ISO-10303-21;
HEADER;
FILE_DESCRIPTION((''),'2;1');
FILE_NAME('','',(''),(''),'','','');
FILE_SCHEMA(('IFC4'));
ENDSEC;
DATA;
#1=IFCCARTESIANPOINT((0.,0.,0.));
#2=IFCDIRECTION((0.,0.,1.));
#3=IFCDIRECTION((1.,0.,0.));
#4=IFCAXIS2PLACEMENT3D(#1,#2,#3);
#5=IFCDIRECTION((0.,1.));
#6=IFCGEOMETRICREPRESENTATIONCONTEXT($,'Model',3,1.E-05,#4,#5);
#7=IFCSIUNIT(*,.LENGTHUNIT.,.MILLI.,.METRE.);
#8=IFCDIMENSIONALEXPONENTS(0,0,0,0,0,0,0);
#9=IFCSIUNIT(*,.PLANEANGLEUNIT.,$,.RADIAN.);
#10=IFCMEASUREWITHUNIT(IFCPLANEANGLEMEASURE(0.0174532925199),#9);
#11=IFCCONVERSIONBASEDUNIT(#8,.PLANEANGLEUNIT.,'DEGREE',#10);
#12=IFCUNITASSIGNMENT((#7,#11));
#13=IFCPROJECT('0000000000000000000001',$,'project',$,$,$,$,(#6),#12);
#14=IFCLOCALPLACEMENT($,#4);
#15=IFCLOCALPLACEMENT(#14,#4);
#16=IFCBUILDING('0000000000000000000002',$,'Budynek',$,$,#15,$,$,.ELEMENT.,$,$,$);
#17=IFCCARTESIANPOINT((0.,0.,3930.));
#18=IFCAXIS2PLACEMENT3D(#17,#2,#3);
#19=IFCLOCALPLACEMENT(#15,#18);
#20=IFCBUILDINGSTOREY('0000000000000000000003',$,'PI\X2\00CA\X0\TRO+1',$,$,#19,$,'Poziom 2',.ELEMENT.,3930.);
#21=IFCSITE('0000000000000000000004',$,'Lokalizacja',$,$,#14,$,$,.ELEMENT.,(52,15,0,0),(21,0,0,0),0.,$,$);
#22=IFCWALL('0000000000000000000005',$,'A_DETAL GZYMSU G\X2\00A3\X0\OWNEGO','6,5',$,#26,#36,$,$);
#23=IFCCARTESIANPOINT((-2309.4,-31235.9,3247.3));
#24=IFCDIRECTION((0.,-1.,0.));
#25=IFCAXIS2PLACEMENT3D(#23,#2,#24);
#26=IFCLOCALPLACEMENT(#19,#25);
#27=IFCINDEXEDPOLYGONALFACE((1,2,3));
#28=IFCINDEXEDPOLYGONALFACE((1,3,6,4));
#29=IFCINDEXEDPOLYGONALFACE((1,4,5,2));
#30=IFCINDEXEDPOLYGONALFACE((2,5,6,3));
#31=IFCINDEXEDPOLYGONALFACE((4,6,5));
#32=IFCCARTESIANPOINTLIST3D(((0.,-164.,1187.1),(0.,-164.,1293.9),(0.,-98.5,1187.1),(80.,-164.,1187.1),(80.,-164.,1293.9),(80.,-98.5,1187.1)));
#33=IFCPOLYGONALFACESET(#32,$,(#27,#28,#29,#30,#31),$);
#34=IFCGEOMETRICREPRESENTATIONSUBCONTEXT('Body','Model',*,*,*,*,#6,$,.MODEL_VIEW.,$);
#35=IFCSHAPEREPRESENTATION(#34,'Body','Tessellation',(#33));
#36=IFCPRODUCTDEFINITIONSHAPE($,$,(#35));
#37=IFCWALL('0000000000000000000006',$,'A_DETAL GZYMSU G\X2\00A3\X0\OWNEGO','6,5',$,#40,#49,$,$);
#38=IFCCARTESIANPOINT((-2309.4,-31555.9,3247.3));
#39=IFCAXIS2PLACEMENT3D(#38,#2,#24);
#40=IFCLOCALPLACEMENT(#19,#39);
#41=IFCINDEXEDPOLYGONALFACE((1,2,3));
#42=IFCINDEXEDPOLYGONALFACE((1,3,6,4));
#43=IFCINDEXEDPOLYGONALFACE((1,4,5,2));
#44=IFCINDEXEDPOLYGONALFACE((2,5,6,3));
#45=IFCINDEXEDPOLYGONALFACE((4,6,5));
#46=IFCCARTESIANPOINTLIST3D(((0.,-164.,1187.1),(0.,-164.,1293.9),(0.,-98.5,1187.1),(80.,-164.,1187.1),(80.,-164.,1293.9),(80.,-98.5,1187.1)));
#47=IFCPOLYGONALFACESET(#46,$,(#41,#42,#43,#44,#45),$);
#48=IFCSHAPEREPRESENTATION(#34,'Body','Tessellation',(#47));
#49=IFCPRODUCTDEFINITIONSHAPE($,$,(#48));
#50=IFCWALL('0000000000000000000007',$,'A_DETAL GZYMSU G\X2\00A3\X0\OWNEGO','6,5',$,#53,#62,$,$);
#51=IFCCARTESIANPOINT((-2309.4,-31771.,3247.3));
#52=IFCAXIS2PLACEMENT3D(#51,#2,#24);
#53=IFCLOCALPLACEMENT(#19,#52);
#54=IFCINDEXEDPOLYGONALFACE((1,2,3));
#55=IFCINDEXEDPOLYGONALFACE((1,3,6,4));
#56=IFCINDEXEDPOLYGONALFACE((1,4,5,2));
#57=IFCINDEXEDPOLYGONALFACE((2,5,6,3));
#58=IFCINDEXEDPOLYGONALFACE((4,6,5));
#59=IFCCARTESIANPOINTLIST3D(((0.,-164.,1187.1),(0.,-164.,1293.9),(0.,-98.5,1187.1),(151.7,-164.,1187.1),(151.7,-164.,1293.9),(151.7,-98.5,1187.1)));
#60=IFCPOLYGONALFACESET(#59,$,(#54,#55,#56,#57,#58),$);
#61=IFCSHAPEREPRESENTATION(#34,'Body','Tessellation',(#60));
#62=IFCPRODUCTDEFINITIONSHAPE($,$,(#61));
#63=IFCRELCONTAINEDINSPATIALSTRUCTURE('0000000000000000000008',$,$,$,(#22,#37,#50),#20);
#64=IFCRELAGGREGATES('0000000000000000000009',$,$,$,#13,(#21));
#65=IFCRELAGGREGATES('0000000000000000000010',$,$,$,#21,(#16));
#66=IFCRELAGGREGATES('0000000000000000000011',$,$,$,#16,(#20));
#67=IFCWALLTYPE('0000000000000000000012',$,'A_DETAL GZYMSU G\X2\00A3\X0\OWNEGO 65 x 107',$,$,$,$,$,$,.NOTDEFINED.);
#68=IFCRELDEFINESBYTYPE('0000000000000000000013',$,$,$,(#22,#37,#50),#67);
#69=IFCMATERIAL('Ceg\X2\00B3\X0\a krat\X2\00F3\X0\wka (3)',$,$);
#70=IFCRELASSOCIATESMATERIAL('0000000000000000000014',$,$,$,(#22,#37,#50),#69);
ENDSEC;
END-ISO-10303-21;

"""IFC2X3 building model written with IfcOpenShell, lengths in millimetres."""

from ifc_helpers import new_model, entity, si_unit, converted_unit, direction, frame, origin_with_axes, place, context, subcontext, project, spatial, polyline, outline, extrude, material, type_object, element, save


model = new_model("IFC2X3")

# Units and contexts
model_context = context("Model", 3, precision=1e-05, world=origin_with_axes(), true_north=direction((0.0, 1.0)))
body_context = subcontext(model_context, "Body", "Model", "MODEL_VIEW")
ifc_project = project(units=[si_unit("LENGTHUNIT", "METRE", prefix="MILLI"), converted_unit("PLANEANGLEUNIT", "DEGREE", entity("IfcPlaneAngleMeasure", 0.0174532925199), si_unit("PLANEANGLEUNIT", "RADIAN"), dimensions=[0, 0, 0, 0, 0, 0, 0])], contexts=[model_context])

# Site, building, storey
site_placement = place(None, origin_with_axes())
site = spatial("IfcSite", under=ifc_project, at=site_placement, Name="Lokalizacja", CompositionType="ELEMENT", RefLatitude=(52, 15, 0, 0), RefLongitude=(21, 0, 0, 0), RefElevation=0.0)
building_placement = place(site_placement, origin_with_axes())
building = spatial("IfcBuilding", under=site, at=building_placement, Name="Budynek", CompositionType="ELEMENT")
storey_placement = place(building_placement, frame((0.0, 0.0, 3930.0), z_axis=(0.0, 0.0, 1.0), x_axis=(1.0, 0.0, 0.0)))
storey = spatial("IfcBuildingStorey", under=building, at=storey_placement, Name="PIÊTRO+1", LongName="Poziom 2", CompositionType="ELEMENT", Elevation=3930.0)

# Walls
ifc_material = material(Name="Ceg³a kratówka (3)")
wall_type_1 = type_object("IfcWallType", Name="A_DETAL GZYMSU G£OWNEGO 65 x 107", PredefinedType="NOTDEFINED")
for number, where, z_axis, x_axis, name in (
    (1, (-2309.4, -31235.9, 3247.3), (0.0, 0.0, 1.0), (0.0, -1.0, 0.0), "A_DETAL GZYMSU G£OWNEGO"),
    (2, (-2309.4, -31555.9, 3247.3), (0.0, 0.0, 1.0), (0.0, -1.0, 0.0), "A_DETAL GZYMSU G£OWNEGO"),
):
    element("IfcWall", number, at=place(storey_placement, frame(where, z_axis=z_axis, x_axis=x_axis)), inside=storey, type_object=wall_type_1, material=ifc_material, Name=name, Description="6,5", context=body_context, shape_type="SweptSolid", body=[
        extrude(outline(polyline([(-164.0, 1293.9), (-164.0, 1187.1), (-98.5, 1187.1), (-164.0, 1293.9)])), frame((0.0, 0.0, 0.0), z_axis=(1.0, 0.0, 0.0), x_axis=(0.0, 1.0, 0.0)), (0.0, 0.0, 1.0), 80.0),
    ])
wall_1_placement = place(storey_placement, frame((-2309.4, -31771.0, 3247.3), z_axis=(0.0, 0.0, 1.0), x_axis=(0.0, -1.0, 0.0)))
element("IfcWall", 3, at=wall_1_placement, inside=storey, type_object=wall_type_1, material=ifc_material, Name="A_DETAL GZYMSU G£OWNEGO", Description="6,5", context=body_context, shape_type="SweptSolid", body=[
    extrude(outline(polyline([(-164.0, 1293.9), (-164.0, 1187.1), (-98.5, 1187.1), (-164.0, 1293.9)])), frame((0.0, 0.0, 0.0), z_axis=(1.0, 0.0, 0.0), x_axis=(0.0, 1.0, 0.0)), (0.0, 0.0, 1.0), 151.7),
])

save(model, "model.ifc")
